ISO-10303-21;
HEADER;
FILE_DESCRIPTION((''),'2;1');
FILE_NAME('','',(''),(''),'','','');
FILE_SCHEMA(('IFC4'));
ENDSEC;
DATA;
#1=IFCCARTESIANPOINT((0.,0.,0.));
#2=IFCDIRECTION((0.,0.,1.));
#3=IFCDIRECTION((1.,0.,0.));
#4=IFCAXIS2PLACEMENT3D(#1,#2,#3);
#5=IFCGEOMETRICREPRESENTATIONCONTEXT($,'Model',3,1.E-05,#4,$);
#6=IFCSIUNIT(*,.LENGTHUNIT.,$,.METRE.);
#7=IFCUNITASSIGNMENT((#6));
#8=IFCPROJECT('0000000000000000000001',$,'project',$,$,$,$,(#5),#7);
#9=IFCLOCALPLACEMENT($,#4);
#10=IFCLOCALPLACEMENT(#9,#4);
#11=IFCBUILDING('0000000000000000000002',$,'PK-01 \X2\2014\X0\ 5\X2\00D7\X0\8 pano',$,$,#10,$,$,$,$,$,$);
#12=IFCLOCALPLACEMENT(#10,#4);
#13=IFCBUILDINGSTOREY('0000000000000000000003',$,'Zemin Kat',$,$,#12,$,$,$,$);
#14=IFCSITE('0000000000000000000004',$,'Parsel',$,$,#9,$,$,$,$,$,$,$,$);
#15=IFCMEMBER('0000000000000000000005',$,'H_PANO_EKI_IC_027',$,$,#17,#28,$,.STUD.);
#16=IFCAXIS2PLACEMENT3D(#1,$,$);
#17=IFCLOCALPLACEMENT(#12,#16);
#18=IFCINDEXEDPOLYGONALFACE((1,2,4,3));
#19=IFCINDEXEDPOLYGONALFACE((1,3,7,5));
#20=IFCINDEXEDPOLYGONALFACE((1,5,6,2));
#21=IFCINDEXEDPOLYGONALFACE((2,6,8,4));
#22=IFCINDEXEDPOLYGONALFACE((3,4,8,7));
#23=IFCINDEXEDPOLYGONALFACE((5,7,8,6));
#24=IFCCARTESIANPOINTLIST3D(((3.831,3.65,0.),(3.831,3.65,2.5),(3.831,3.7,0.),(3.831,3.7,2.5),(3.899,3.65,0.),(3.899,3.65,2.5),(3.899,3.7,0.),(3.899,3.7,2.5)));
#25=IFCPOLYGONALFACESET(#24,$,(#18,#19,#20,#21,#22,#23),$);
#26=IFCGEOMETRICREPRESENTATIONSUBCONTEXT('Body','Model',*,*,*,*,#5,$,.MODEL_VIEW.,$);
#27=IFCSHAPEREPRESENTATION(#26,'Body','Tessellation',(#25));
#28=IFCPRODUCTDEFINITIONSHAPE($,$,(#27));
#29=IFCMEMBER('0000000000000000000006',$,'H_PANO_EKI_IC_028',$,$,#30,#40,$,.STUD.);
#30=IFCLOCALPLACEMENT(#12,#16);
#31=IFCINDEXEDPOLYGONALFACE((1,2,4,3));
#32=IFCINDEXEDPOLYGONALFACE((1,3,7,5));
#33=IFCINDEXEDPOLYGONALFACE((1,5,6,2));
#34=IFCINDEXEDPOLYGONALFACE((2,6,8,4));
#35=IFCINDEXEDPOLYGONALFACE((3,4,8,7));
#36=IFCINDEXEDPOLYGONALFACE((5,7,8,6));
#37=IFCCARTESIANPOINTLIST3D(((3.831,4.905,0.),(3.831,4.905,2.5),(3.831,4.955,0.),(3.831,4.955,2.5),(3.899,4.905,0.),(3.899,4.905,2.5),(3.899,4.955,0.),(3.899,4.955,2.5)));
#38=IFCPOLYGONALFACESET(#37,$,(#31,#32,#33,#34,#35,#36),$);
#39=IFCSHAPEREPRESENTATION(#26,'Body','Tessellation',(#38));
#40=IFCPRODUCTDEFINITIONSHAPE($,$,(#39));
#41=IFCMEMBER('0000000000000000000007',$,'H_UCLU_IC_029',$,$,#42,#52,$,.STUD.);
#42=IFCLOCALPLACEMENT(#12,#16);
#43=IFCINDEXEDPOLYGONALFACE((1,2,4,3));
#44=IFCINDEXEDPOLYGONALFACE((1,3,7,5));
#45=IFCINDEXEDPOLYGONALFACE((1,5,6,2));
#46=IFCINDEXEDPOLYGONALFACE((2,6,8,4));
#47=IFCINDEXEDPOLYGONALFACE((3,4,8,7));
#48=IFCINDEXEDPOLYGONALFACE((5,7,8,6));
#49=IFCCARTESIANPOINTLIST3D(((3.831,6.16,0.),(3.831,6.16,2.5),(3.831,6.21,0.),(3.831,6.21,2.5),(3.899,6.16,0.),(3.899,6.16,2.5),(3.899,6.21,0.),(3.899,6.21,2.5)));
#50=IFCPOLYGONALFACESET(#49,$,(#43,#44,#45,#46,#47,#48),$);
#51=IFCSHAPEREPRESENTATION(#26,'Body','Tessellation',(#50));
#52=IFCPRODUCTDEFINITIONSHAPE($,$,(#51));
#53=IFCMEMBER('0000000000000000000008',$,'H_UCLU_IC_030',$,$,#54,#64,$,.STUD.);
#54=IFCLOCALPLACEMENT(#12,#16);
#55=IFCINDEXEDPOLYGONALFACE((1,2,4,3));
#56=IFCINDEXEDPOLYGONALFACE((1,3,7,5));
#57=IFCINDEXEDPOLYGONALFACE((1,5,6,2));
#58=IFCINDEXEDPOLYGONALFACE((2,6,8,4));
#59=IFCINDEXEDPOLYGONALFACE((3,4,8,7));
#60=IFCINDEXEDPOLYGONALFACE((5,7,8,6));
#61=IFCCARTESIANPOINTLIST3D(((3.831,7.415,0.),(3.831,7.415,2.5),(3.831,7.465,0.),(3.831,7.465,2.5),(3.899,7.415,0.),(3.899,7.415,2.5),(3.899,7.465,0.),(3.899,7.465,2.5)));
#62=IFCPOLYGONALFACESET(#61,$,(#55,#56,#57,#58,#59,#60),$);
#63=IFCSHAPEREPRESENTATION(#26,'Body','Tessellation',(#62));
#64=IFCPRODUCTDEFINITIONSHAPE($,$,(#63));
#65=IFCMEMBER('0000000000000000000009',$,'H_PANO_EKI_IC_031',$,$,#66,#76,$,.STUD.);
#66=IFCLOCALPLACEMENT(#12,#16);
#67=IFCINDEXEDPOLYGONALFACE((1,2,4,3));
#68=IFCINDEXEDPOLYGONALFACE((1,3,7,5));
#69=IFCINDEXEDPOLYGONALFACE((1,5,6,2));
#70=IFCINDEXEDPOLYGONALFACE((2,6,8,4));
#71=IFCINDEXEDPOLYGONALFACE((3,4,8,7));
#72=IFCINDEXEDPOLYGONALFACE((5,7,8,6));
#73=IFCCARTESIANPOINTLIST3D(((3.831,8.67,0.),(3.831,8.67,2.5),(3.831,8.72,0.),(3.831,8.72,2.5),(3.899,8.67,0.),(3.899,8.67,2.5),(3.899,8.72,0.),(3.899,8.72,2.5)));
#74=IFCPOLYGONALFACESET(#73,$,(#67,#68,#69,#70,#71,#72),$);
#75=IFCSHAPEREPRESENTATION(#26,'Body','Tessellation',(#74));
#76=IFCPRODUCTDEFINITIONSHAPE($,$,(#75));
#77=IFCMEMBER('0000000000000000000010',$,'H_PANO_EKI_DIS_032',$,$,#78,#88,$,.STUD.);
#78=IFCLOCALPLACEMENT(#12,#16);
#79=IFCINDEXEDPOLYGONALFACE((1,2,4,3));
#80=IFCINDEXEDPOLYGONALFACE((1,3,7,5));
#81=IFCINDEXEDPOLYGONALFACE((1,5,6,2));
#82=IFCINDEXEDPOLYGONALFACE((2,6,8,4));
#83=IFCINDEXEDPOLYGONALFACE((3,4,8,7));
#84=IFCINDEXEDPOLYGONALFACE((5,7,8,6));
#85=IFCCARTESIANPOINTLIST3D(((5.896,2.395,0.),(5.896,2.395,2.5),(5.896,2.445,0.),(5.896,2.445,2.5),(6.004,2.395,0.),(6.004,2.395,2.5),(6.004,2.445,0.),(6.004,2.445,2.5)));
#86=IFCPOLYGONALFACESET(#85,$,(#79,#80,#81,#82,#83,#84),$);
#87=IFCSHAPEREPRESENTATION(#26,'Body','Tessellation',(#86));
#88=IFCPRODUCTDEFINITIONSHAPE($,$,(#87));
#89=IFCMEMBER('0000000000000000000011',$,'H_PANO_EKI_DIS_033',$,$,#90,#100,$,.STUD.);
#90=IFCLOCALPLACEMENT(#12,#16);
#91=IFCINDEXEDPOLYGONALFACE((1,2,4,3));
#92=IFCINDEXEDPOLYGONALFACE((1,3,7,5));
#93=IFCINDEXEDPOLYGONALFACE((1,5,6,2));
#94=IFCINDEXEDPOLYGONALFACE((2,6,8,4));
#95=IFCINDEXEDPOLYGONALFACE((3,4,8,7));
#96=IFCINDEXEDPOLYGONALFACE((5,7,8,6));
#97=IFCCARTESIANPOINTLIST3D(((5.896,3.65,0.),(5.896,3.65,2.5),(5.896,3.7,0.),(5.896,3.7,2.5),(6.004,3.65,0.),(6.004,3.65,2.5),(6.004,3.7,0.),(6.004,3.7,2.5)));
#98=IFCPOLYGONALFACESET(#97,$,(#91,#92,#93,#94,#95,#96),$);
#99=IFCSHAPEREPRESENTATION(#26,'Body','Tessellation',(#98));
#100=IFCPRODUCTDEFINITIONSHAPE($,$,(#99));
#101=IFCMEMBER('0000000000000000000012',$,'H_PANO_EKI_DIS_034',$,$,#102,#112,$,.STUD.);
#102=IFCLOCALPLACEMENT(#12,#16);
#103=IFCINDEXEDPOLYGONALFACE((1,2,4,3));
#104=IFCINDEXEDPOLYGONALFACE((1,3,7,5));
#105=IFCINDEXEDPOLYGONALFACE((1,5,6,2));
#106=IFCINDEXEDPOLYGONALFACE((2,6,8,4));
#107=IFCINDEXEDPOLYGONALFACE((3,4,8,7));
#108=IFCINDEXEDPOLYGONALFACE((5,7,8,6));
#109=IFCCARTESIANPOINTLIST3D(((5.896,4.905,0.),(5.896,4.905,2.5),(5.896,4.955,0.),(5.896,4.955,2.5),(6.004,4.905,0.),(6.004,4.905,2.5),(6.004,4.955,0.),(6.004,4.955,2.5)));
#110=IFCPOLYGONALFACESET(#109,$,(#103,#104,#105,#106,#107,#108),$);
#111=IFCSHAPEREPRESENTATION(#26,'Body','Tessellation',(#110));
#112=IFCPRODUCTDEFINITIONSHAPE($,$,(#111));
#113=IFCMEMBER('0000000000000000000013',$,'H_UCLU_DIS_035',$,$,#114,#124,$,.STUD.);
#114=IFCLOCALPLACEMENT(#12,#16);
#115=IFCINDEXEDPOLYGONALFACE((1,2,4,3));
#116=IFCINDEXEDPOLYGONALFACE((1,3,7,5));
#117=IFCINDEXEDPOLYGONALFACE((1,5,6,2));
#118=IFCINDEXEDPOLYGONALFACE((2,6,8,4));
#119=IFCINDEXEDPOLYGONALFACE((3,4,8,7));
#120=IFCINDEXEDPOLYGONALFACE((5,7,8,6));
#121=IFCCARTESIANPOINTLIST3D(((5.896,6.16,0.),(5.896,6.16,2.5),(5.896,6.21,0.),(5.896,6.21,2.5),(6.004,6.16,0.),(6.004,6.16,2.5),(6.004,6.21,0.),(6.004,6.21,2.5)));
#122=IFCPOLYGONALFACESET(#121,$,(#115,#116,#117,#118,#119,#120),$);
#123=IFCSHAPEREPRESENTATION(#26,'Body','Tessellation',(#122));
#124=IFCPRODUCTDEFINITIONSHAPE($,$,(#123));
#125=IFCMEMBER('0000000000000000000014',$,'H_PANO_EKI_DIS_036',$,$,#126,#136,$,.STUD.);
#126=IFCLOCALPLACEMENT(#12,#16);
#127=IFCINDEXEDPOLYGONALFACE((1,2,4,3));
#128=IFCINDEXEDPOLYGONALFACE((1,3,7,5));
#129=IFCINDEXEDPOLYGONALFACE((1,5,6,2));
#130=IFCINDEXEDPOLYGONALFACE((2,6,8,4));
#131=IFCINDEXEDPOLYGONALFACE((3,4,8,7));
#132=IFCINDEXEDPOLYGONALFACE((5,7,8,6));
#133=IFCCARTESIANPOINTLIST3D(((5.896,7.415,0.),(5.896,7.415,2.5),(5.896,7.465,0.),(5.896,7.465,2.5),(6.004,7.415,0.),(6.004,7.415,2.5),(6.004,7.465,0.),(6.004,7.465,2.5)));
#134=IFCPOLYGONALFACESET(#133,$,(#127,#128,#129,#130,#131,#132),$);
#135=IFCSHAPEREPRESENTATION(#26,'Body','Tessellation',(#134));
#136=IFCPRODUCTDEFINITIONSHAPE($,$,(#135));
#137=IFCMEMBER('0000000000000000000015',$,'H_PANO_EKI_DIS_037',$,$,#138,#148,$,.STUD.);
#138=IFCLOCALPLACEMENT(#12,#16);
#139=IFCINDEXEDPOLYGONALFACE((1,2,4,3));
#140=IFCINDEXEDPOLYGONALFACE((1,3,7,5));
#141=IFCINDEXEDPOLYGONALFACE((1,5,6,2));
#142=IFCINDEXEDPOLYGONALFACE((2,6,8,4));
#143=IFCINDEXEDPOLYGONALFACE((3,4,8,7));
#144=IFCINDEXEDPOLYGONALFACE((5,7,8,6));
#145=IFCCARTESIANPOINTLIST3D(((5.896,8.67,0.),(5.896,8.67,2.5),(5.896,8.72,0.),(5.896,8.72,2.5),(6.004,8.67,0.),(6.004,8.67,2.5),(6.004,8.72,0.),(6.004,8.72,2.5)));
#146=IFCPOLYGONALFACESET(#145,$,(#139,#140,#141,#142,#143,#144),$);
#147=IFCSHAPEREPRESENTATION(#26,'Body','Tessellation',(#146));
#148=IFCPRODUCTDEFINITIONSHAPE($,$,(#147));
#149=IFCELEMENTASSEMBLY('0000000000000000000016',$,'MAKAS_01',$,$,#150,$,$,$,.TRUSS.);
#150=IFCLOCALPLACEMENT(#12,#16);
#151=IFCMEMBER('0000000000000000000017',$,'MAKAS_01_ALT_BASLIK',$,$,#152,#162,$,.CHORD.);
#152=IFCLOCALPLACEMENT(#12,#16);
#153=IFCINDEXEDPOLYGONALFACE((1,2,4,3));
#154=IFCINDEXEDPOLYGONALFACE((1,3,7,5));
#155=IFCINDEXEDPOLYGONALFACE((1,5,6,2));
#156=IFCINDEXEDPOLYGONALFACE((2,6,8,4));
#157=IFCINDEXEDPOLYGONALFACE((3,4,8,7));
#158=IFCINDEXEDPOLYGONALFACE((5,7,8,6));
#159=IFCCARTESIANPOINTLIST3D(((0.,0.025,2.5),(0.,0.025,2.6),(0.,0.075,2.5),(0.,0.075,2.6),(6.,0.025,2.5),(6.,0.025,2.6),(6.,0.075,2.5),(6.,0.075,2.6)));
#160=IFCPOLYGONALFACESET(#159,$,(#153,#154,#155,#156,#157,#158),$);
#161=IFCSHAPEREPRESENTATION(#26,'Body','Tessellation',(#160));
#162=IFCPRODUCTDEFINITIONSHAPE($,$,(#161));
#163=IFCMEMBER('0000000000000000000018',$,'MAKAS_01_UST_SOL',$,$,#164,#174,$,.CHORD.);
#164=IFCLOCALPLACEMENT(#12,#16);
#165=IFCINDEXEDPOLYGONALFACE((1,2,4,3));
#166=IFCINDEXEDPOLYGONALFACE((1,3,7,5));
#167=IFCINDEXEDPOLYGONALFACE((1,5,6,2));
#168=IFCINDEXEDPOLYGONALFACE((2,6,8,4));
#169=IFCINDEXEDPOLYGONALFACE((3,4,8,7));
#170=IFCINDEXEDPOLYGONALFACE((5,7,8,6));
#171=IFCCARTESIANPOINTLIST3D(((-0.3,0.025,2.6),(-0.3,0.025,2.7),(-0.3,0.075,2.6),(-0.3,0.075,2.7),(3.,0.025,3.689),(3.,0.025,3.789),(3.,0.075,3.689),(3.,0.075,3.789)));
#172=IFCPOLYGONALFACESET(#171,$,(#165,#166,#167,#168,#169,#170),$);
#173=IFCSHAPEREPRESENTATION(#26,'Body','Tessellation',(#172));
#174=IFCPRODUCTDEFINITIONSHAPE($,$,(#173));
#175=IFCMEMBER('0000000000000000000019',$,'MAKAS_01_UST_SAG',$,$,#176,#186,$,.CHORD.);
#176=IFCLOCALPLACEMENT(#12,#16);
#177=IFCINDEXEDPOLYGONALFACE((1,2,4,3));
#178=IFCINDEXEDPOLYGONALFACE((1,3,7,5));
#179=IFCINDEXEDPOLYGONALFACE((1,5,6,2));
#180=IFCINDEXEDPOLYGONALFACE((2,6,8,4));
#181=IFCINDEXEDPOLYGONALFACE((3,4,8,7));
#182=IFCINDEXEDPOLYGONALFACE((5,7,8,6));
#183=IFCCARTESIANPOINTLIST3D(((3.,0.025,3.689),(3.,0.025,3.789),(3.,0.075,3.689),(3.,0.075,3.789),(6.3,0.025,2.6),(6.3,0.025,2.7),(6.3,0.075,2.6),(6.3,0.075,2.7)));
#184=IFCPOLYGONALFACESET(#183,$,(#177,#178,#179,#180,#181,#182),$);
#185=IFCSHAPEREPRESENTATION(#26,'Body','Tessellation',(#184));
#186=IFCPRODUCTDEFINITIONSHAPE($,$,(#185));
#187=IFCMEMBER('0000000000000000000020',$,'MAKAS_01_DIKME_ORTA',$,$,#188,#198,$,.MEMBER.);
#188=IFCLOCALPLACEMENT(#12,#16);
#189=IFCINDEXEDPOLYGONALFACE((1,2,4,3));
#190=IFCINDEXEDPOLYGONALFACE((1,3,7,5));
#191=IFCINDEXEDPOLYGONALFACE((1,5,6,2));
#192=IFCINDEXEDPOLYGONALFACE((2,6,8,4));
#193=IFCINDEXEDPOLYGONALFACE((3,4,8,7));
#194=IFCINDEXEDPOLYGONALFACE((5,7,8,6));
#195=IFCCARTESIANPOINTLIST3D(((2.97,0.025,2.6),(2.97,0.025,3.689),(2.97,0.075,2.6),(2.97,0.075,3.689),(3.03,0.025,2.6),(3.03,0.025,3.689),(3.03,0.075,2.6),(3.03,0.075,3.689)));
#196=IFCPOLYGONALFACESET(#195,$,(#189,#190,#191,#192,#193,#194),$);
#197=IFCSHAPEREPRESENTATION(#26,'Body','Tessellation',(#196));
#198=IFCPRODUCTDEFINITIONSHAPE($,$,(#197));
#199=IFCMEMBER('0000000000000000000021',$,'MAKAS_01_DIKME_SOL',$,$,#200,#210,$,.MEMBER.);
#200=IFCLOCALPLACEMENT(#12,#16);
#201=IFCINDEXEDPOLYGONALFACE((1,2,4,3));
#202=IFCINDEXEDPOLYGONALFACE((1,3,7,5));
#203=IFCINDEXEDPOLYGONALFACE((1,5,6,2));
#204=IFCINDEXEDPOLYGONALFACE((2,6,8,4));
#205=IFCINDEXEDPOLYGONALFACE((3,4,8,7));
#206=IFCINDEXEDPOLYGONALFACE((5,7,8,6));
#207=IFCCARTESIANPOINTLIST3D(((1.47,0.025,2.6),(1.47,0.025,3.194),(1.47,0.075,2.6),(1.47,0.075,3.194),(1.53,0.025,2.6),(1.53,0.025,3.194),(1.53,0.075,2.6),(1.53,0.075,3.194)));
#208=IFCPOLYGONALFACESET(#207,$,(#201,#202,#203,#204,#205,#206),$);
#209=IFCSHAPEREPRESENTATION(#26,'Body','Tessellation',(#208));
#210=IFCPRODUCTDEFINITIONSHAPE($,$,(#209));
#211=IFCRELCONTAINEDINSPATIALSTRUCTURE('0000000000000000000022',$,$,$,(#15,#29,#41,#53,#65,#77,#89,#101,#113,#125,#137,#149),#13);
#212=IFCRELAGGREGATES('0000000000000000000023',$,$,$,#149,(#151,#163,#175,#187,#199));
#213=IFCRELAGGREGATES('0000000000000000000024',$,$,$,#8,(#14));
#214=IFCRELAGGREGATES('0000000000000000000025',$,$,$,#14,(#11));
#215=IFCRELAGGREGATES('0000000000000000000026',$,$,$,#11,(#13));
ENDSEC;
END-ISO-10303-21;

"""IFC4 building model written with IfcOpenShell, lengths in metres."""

from ifc_helpers import new_model, si_unit, frame, origin_with_axes, place, context, subcontext, project, spatial, line, indexed_curve, outline, extrude, element, aggregate, save


model = new_model("IFC4")

# Units and contexts
model_context = context("Model", 3, precision=1e-05, world=origin_with_axes())
body_context = subcontext(model_context, "Body", "Model", "MODEL_VIEW")
ifc_project = project(units=[si_unit("LENGTHUNIT", "METRE")], contexts=[model_context])

# Site, building, storey
site_placement = place(None, origin_with_axes())
site = spatial("IfcSite", under=ifc_project, at=site_placement, Name="Parsel")
building_placement = place(site_placement, origin_with_axes())
building = spatial("IfcBuilding", under=site, at=building_placement, Name="PK-01 — 5×8 pano")
storey_placement = place(building_placement, origin_with_axes())
storey = spatial("IfcBuildingStorey", under=building, at=storey_placement, Name="Zemin Kat")

# Members
member_1_placement = place(storey_placement, origin_with_axes())
element("IfcMember", 1, at=member_1_placement, inside=storey, Name="H_PANO_EKI_IC_027", PredefinedType="STUD", context=body_context, shape_type="SweptSolid", body=[
    extrude(outline(indexed_curve([(3.831, 3.65), (3.899, 3.65), (3.899, 3.7), (3.831, 3.7)], segments=[line(1, 2, 3, 4, 1)])), origin_with_axes(), (0.0, 0.0, 1.0), 2.5),
])
member_2_placement = place(storey_placement, origin_with_axes())
element("IfcMember", 2, at=member_2_placement, inside=storey, Name="H_PANO_EKI_IC_028", PredefinedType="STUD", context=body_context, shape_type="SweptSolid", body=[
    extrude(outline(indexed_curve([(3.831, 4.905), (3.899, 4.905), (3.899, 4.955), (3.831, 4.955)], segments=[line(1, 2, 3, 4, 1)])), origin_with_axes(), (0.0, 0.0, 1.0), 2.5),
])
member_3_placement = place(storey_placement, origin_with_axes())
element("IfcMember", 3, at=member_3_placement, inside=storey, Name="H_UCLU_IC_029", PredefinedType="STUD", context=body_context, shape_type="SweptSolid", body=[
    extrude(outline(indexed_curve([(3.831, 6.16), (3.899, 6.16), (3.899, 6.21), (3.831, 6.21)], segments=[line(1, 2, 3, 4, 1)])), origin_with_axes(), (0.0, 0.0, 1.0), 2.5),
])
member_4_placement = place(storey_placement, origin_with_axes())
element("IfcMember", 4, at=member_4_placement, inside=storey, Name="H_UCLU_IC_030", PredefinedType="STUD", context=body_context, shape_type="SweptSolid", body=[
    extrude(outline(indexed_curve([(3.831, 7.415), (3.899, 7.415), (3.899, 7.465), (3.831, 7.465)], segments=[line(1, 2, 3, 4, 1)])), origin_with_axes(), (0.0, 0.0, 1.0), 2.5),
])
member_5_placement = place(storey_placement, origin_with_axes())
element("IfcMember", 5, at=member_5_placement, inside=storey, Name="H_PANO_EKI_IC_031", PredefinedType="STUD", context=body_context, shape_type="SweptSolid", body=[
    extrude(outline(indexed_curve([(3.831, 8.67), (3.899, 8.67), (3.899, 8.72), (3.831, 8.72)], segments=[line(1, 2, 3, 4, 1)])), origin_with_axes(), (0.0, 0.0, 1.0), 2.5),
])
member_6_placement = place(storey_placement, origin_with_axes())
element("IfcMember", 6, at=member_6_placement, inside=storey, Name="H_PANO_EKI_DIS_032", PredefinedType="STUD", context=body_context, shape_type="SweptSolid", body=[
    extrude(outline(indexed_curve([(5.896, 2.395), (6.004, 2.395), (6.004, 2.445), (5.896, 2.445)], segments=[line(1, 2, 3, 4, 1)])), origin_with_axes(), (0.0, 0.0, 1.0), 2.5),
])
member_7_placement = place(storey_placement, origin_with_axes())
element("IfcMember", 7, at=member_7_placement, inside=storey, Name="H_PANO_EKI_DIS_033", PredefinedType="STUD", context=body_context, shape_type="SweptSolid", body=[
    extrude(outline(indexed_curve([(5.896, 3.65), (6.004, 3.65), (6.004, 3.7), (5.896, 3.7)], segments=[line(1, 2, 3, 4, 1)])), origin_with_axes(), (0.0, 0.0, 1.0), 2.5),
])
member_8_placement = place(storey_placement, origin_with_axes())
element("IfcMember", 8, at=member_8_placement, inside=storey, Name="H_PANO_EKI_DIS_034", PredefinedType="STUD", context=body_context, shape_type="SweptSolid", body=[
    extrude(outline(indexed_curve([(5.896, 4.905), (6.004, 4.905), (6.004, 4.955), (5.896, 4.955)], segments=[line(1, 2, 3, 4, 1)])), origin_with_axes(), (0.0, 0.0, 1.0), 2.5),
])
member_9_placement = place(storey_placement, origin_with_axes())
element("IfcMember", 9, at=member_9_placement, inside=storey, Name="H_UCLU_DIS_035", PredefinedType="STUD", context=body_context, shape_type="SweptSolid", body=[
    extrude(outline(indexed_curve([(5.896, 6.16), (6.004, 6.16), (6.004, 6.21), (5.896, 6.21)], segments=[line(1, 2, 3, 4, 1)])), origin_with_axes(), (0.0, 0.0, 1.0), 2.5),
])
member_10_placement = place(storey_placement, origin_with_axes())
element("IfcMember", 10, at=member_10_placement, inside=storey, Name="H_PANO_EKI_DIS_036", PredefinedType="STUD", context=body_context, shape_type="SweptSolid", body=[
    extrude(outline(indexed_curve([(5.896, 7.415), (6.004, 7.415), (6.004, 7.465), (5.896, 7.465)], segments=[line(1, 2, 3, 4, 1)])), origin_with_axes(), (0.0, 0.0, 1.0), 2.5),
])
member_11_placement = place(storey_placement, origin_with_axes())
element("IfcMember", 11, at=member_11_placement, inside=storey, Name="H_PANO_EKI_DIS_037", PredefinedType="STUD", context=body_context, shape_type="SweptSolid", body=[
    extrude(outline(indexed_curve([(5.896, 8.67), (6.004, 8.67), (6.004, 8.72), (5.896, 8.72)], segments=[line(1, 2, 3, 4, 1)])), origin_with_axes(), (0.0, 0.0, 1.0), 2.5),
])

# Element assembly, members
assembly_placement = place(storey_placement, origin_with_axes())
assembly = element("IfcElementAssembly", 12, at=assembly_placement, inside=storey, Name="MAKAS_01", PredefinedType="TRUSS")
member_12_placement = place(assembly_placement, origin_with_axes())
member_12 = element("IfcMember", 13, at=member_12_placement, Name="MAKAS_01_ALT_BASLIK", PredefinedType="CHORD", context=body_context, shape_type="SweptSolid", body=[
    extrude(outline(indexed_curve([(0.0, 2.5), (6.0, 2.5), (6.0, 2.6), (0.0, 2.6)], segments=[line(1, 2, 3, 4, 1)])), frame((0.0, 0.075, 0.0), z_axis=(0.0, -1.0, 0.0), x_axis=(1.0, 0.0, 0.0)), (0.0, 0.0, 1.0), 0.05),
])
member_13_placement = place(assembly_placement, origin_with_axes())
member_13 = element("IfcMember", 14, at=member_13_placement, Name="MAKAS_01_UST_SOL", PredefinedType="CHORD", context=body_context, shape_type="SweptSolid", body=[
    extrude(outline(indexed_curve([(-0.3, 2.6), (3.0, 3.689), (3.0, 3.789), (-0.3, 2.7)], segments=[line(1, 2, 3, 4, 1)])), frame((0.0, 0.075, 0.0), z_axis=(0.0, -1.0, 0.0), x_axis=(1.0, 0.0, 0.0)), (0.0, 0.0, 1.0), 0.05),
])
member_14_placement = place(assembly_placement, origin_with_axes())
member_14 = element("IfcMember", 15, at=member_14_placement, Name="MAKAS_01_UST_SAG", PredefinedType="CHORD", context=body_context, shape_type="SweptSolid", body=[
    extrude(outline(indexed_curve([(3.0, 3.689), (6.3, 2.6), (6.3, 2.7), (3.0, 3.789)], segments=[line(1, 2, 3, 4, 1)])), frame((0.0, 0.075, 0.0), z_axis=(0.0, -1.0, 0.0), x_axis=(1.0, 0.0, 0.0)), (0.0, 0.0, 1.0), 0.05),
])
member_15_placement = place(assembly_placement, origin_with_axes())
member_15 = element("IfcMember", 16, at=member_15_placement, Name="MAKAS_01_DIKME_ORTA", PredefinedType="MEMBER", context=body_context, shape_type="SweptSolid", body=[
    extrude(outline(indexed_curve([(2.97, 2.6), (3.03, 2.6), (3.03, 3.689), (2.97, 3.689)], segments=[line(1, 2, 3, 4, 1)])), frame((0.0, 0.075, 0.0), z_axis=(0.0, -1.0, 0.0), x_axis=(1.0, 0.0, 0.0)), (0.0, 0.0, 1.0), 0.05),
])
member_16_placement = place(assembly_placement, origin_with_axes())
member_16 = element("IfcMember", 17, at=member_16_placement, Name="MAKAS_01_DIKME_SOL", PredefinedType="MEMBER", context=body_context, shape_type="SweptSolid", body=[
    extrude(outline(indexed_curve([(1.47, 2.6), (1.53, 2.6), (1.53, 3.194), (1.47, 3.194)], segments=[line(1, 2, 3, 4, 1)])), frame((0.0, 0.075, 0.0), z_axis=(0.0, -1.0, 0.0), x_axis=(1.0, 0.0, 0.0)), (0.0, 0.0, 1.0), 0.05),
])
aggregate(assembly, [member_12, member_13, member_14, member_15, member_16])

save(model, "model.ifc")
